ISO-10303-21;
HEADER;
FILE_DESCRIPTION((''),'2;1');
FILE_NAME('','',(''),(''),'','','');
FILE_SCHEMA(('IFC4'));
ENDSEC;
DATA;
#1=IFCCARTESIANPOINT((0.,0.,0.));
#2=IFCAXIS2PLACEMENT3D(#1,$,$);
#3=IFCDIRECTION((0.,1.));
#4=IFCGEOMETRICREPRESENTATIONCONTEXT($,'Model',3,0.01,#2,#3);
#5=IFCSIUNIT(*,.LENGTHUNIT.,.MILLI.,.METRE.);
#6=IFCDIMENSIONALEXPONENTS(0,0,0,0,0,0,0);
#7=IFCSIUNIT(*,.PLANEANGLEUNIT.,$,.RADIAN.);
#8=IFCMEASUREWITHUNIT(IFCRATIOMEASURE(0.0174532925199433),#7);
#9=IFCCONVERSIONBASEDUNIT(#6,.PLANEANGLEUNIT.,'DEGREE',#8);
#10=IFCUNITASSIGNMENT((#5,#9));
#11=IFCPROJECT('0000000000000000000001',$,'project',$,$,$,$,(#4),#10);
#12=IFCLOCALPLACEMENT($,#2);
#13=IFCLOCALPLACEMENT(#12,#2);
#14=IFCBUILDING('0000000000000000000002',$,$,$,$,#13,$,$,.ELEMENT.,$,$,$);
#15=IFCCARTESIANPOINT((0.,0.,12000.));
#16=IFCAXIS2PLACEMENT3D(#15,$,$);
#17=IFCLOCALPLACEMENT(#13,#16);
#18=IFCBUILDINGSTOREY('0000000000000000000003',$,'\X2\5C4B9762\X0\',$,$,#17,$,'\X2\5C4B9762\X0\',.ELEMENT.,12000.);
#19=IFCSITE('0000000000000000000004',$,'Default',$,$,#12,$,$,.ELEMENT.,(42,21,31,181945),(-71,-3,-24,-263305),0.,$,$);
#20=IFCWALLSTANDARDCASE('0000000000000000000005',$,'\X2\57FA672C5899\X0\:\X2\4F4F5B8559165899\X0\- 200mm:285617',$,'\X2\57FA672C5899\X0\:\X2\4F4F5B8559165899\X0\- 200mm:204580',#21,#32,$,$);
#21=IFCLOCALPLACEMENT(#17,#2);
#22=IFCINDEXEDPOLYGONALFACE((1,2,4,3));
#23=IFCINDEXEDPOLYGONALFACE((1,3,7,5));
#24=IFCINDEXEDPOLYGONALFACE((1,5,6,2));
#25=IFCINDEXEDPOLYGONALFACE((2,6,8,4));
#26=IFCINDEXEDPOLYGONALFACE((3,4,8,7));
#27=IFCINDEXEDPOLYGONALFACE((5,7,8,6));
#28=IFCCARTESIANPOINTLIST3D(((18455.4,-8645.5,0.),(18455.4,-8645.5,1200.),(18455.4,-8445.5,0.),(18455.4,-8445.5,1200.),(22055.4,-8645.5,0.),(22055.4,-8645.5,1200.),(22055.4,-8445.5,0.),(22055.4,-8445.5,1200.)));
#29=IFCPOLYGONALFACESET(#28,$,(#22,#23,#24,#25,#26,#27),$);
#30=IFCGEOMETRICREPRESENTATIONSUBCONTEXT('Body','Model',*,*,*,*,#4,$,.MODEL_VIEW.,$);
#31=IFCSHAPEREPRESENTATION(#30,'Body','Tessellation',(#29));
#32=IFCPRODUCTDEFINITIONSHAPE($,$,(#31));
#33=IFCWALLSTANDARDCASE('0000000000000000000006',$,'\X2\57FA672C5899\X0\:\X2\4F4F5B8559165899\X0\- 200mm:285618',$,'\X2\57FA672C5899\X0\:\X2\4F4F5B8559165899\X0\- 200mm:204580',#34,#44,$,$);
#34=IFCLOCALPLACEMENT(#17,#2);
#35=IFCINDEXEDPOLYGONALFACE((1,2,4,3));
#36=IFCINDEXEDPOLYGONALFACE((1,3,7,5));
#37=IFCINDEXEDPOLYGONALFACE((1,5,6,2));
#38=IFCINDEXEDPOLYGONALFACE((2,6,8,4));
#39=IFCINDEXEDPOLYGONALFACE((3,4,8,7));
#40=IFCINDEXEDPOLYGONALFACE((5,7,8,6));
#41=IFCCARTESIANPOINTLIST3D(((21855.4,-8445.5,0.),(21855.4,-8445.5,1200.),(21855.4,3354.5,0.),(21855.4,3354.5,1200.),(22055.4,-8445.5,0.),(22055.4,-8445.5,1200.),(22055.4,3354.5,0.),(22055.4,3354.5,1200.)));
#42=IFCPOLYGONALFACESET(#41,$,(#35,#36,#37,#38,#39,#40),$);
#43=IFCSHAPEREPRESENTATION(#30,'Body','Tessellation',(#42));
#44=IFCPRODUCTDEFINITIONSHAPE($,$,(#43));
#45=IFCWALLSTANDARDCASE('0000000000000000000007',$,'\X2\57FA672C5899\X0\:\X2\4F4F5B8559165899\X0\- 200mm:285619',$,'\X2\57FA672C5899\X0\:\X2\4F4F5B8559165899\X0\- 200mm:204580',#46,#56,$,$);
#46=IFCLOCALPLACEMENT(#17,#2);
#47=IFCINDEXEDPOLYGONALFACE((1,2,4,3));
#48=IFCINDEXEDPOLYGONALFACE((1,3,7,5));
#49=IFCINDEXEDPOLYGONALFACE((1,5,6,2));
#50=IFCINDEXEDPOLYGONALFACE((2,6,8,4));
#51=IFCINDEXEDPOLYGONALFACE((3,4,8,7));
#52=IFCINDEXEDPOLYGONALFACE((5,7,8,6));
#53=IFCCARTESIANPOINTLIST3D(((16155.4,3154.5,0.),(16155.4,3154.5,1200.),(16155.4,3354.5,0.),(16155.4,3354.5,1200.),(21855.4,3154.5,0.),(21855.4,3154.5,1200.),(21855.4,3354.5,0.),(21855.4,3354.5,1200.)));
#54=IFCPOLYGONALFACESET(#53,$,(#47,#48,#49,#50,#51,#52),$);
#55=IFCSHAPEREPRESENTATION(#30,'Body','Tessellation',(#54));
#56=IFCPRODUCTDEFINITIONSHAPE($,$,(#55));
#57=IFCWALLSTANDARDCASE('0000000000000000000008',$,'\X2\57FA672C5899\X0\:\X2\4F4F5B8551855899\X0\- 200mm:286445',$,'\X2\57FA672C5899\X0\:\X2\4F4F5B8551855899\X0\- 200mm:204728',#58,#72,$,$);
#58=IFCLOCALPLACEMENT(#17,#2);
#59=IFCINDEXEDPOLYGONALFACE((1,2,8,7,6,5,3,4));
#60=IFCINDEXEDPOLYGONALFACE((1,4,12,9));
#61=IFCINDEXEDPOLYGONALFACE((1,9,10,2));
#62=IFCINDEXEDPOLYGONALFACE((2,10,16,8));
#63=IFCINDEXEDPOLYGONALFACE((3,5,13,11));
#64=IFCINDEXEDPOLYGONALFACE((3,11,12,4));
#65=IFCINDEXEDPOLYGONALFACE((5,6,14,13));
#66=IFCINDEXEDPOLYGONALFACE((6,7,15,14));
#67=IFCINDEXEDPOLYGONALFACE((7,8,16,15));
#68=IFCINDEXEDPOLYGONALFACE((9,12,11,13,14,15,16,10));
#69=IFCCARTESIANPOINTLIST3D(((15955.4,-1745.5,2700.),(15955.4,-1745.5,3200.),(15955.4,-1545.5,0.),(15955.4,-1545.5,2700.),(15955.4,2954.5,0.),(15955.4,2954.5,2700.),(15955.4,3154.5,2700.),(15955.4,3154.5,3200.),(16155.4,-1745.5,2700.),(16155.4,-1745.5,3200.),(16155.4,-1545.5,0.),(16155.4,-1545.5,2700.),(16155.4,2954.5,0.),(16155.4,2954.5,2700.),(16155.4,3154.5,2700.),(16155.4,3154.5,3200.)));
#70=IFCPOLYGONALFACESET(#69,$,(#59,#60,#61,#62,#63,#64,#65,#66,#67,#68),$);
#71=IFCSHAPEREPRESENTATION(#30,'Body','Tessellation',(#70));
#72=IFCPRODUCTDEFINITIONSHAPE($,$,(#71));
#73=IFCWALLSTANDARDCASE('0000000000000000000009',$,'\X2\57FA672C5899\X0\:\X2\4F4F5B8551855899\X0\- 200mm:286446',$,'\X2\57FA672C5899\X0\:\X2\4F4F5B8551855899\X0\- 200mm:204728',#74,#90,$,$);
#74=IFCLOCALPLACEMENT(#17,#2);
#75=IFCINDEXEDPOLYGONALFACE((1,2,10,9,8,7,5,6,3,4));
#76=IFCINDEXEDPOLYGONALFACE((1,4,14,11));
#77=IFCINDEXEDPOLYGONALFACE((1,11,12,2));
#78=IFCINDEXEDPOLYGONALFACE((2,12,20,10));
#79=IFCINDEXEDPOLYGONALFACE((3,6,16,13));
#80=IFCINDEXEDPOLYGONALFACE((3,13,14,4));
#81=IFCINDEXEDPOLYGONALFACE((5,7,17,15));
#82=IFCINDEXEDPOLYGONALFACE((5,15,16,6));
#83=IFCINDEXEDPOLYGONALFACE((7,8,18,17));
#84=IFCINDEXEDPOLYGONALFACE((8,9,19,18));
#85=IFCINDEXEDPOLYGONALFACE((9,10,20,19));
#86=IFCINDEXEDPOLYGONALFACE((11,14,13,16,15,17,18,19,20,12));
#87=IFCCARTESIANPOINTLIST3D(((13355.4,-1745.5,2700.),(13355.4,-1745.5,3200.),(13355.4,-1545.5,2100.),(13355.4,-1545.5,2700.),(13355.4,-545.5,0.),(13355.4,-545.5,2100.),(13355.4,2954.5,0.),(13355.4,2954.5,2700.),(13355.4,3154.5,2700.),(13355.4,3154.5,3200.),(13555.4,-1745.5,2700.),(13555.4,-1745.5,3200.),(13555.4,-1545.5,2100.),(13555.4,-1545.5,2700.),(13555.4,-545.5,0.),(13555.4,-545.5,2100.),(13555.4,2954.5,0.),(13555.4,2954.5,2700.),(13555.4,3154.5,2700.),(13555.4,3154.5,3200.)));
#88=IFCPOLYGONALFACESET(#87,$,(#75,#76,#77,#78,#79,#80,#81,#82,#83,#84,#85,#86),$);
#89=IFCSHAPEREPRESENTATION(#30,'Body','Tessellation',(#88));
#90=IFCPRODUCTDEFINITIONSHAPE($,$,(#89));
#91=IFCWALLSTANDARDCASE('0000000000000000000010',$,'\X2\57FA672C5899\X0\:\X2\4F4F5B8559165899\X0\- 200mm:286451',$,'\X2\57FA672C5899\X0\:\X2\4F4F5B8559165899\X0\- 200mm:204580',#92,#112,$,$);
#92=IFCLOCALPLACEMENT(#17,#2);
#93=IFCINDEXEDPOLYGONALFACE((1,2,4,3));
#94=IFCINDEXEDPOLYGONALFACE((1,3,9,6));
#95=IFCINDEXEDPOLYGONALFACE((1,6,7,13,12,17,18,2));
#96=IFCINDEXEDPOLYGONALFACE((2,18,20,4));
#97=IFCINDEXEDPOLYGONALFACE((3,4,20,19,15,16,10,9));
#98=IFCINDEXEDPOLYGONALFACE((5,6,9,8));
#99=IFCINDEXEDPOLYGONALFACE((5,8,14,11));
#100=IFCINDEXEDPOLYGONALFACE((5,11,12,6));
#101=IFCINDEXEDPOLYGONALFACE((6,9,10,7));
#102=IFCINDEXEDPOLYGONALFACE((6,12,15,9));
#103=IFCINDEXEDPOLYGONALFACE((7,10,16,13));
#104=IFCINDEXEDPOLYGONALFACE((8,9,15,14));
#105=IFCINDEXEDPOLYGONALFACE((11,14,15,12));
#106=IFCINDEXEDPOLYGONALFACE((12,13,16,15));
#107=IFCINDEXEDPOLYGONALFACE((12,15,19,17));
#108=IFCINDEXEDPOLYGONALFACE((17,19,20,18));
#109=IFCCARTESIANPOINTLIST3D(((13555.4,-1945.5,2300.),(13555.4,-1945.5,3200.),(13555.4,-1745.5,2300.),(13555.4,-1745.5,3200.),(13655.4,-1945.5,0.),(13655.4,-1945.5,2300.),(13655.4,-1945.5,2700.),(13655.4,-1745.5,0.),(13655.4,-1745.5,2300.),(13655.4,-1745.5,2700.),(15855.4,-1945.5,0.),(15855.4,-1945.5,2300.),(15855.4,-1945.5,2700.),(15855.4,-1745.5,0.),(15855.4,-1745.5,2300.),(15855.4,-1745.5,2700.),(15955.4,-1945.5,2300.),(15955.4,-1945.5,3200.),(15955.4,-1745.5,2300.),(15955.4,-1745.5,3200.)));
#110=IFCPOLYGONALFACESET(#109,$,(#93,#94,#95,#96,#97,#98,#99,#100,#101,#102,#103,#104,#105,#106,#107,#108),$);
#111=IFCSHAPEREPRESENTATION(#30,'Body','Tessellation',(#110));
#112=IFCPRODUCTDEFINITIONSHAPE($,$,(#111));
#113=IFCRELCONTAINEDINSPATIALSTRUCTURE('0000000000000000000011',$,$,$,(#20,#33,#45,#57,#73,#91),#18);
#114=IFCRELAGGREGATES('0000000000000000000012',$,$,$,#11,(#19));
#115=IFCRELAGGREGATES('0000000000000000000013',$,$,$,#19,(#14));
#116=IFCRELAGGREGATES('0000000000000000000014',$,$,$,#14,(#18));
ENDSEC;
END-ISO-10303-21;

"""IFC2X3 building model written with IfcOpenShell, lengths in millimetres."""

from ifc_helpers import new_model, entity, si_unit, converted_unit, direction, frame, frame_2d, origin, place, context, subcontext, project, spatial, polyline, rectangle, extrude, clip, bounded_halfspace, element, save


model = new_model("IFC2X3")

# Units and contexts
model_context = context("Model", 3, precision=0.01, world=origin(), true_north=direction((0.0, 1.0)))
body_context = subcontext(model_context, "Body", "Model", "MODEL_VIEW")
ifc_project = project(units=[si_unit("LENGTHUNIT", "METRE", prefix="MILLI"), converted_unit("PLANEANGLEUNIT", "DEGREE", entity("IfcRatioMeasure", 0.0174532925199433), si_unit("PLANEANGLEUNIT", "RADIAN"), dimensions=[0, 0, 0, 0, 0, 0, 0])], contexts=[model_context])

# Site, building, storey
site_placement = place(None, origin())
site = spatial("IfcSite", under=ifc_project, at=site_placement, Name="Default", CompositionType="ELEMENT", RefLatitude=(42, 21, 31, 181945), RefLongitude=(-71, -3, -24, -263305), RefElevation=0.0)
building_placement = place(site_placement, origin())
building = spatial("IfcBuilding", under=site, at=building_placement, CompositionType="ELEMENT")
storey_placement = place(building_placement, frame((0.0, 0.0, 12000.0)))
storey = spatial("IfcBuildingStorey", under=building, at=storey_placement, Name="屋面", LongName="屋面", CompositionType="ELEMENT", Elevation=12000.0)

# Walls
wall_1_placement = place(storey_placement, frame((18455.4, -8545.5, 0.0)))
element("IfcWallStandardCase", 1, at=wall_1_placement, inside=storey, Name="基本墙:住宅外墙- 200mm:285617", ObjectType="基本墙:住宅外墙- 200mm:204580", context=body_context, shape_type="SweptSolid", body=[
    extrude(rectangle(XDim=3600.0, YDim=200.0, at=frame_2d((1800.0, 0.0), x_axis=(-1.0, 0.0))), origin(), (0.0, 0.0, 1.0), 1200.0),
])
wall_2_placement = place(storey_placement, frame((21955.4, -8445.5, 0.0), z_axis=(0.0, 0.0, 1.0), x_axis=(0.0, 1.0, 0.0)))
element("IfcWallStandardCase", 2, at=wall_2_placement, inside=storey, Name="基本墙:住宅外墙- 200mm:285618", ObjectType="基本墙:住宅外墙- 200mm:204580", context=body_context, shape_type="SweptSolid", body=[
    extrude(rectangle(XDim=11800.0, YDim=200.0, at=frame_2d((5900.0, 0.0), x_axis=(-1.0, 0.0))), origin(), (0.0, 0.0, 1.0), 1200.0),
])
wall_3_placement = place(storey_placement, frame((21855.4, 3254.5, 0.0), z_axis=(0.0, 0.0, 1.0), x_axis=(-1.0, 0.0, 0.0)))
element("IfcWallStandardCase", 3, at=wall_3_placement, inside=storey, Name="基本墙:住宅外墙- 200mm:285619", ObjectType="基本墙:住宅外墙- 200mm:204580", context=body_context, shape_type="SweptSolid", body=[
    extrude(rectangle(XDim=5700.0, YDim=200.0, at=frame_2d((2850.0, 0.0), x_axis=(-1.0, 0.0))), origin(), (0.0, 0.0, 1.0), 1200.0),
])
wall_4_placement = place(storey_placement, frame((16055.4, 3154.5, 0.0), z_axis=(0.0, 0.0, 1.0), x_axis=(0.0, -1.0, 0.0)))
element("IfcWallStandardCase", 4, at=wall_4_placement, inside=storey, Name="基本墙:住宅内墙- 200mm:286445", ObjectType="基本墙:住宅内墙- 200mm:204728", context=body_context, shape_type="Clipping", body=[
    clip(clip(clip(clip(extrude(rectangle(XDim=4900.0, YDim=200.0, at=frame_2d((2450.0, 0.0), x_axis=(-1.0, 0.0))), origin(), (0.0, 0.0, 1.0), 3200.0), bounded_halfspace(frame((200.0, -100.0, 2700.0), z_axis=(-1.0, 0.0, 0.0), x_axis=(0.0, 0.0, -1.0)), False, frame((200.0, -100.0, 2700.0), z_axis=(-1.0, 0.0, 0.0), x_axis=(0.0, 0.0, -1.0)), polyline([(0.0, 0.0), (0.0, -200.0), (2700.0, -200.0), (2700.0, 0.0), (0.0, 0.0)]))), bounded_halfspace(frame((200.0, 100.0, 2700.0), z_axis=(0.0, 0.0, -1.0), x_axis=(0.0, 1.0, 0.0)), False, frame((200.0, 100.0, 2700.0), z_axis=(0.0, 0.0, -1.0), x_axis=(0.0, 1.0, 0.0)), polyline([(0.0, 0.0), (-200.0, 0.0), (-200.0, -200.0), (0.0, -200.0), (0.0, 0.0)]))), bounded_halfspace(frame((4700.0, 100.0, 2700.0), z_axis=(-1.0, 0.0, 0.0), x_axis=(0.0, 0.0, -1.0)), True, frame((4700.0, 100.0, 2700.0), z_axis=(-1.0, 0.0, 0.0), x_axis=(0.0, 0.0, -1.0)), polyline([(0.0, 0.0), (2700.0, 0.0), (2700.0, 200.0), (0.0, 200.0), (0.0, 0.0)]))), bounded_halfspace(frame((4700.0, -100.0, 2700.0), z_axis=(0.0, 0.0, 1.0), x_axis=(0.0, -1.0, 0.0)), True, frame((4700.0, -100.0, 2700.0), z_axis=(0.0, 0.0, 1.0), x_axis=(0.0, -1.0, 0.0)), polyline([(0.0, 0.0), (0.0, 200.0), (-200.0, 200.0), (-200.0, 0.0), (0.0, 0.0)]))),
])

# Walls, openings
wall_5_placement = place(storey_placement, frame((13455.4, -1745.5, 0.0), z_axis=(0.0, 0.0, 1.0), x_axis=(0.0, 1.0, 0.0)))
wall_5 = element("IfcWallStandardCase", 5, at=wall_5_placement, inside=storey, Name="基本墙:住宅内墙- 200mm:286446", ObjectType="基本墙:住宅内墙- 200mm:204728", context=body_context, shape_type="Clipping", body=[
    clip(clip(clip(clip(extrude(rectangle(XDim=4900.0, YDim=200.0, at=frame_2d((2450.0, 0.0), x_axis=(-1.0, 0.0))), origin(), (0.0, 0.0, 1.0), 3200.0), bounded_halfspace(frame((200.0, -100.0, 2700.0), z_axis=(1.0, 0.0, 0.0), x_axis=(0.0, 0.0, -1.0)), True, frame((200.0, -100.0, 2700.0), z_axis=(1.0, 0.0, 0.0), x_axis=(0.0, 0.0, -1.0)), polyline([(0.0, 0.0), (600.0, 0.0), (600.0, 200.0), (0.0, 200.0), (0.0, 0.0)]))), bounded_halfspace(frame((200.0, 100.0, 2700.0), z_axis=(0.0, 0.0, 1.0), x_axis=(0.0, 1.0, 0.0)), True, frame((200.0, 100.0, 2700.0), z_axis=(0.0, 0.0, 1.0), x_axis=(0.0, 1.0, 0.0)), polyline([(0.0, 0.0), (0.0, 200.0), (-200.0, 200.0), (-200.0, 0.0), (0.0, 0.0)]))), bounded_halfspace(frame((4700.0, 100.0, 2700.0), z_axis=(-1.0, 0.0, 0.0), x_axis=(0.0, 0.0, -1.0)), True, frame((4700.0, 100.0, 2700.0), z_axis=(-1.0, 0.0, 0.0), x_axis=(0.0, 0.0, -1.0)), polyline([(0.0, 0.0), (2700.0, 0.0), (2700.0, 200.0), (0.0, 200.0), (0.0, 0.0)]))), bounded_halfspace(frame((4700.0, -100.0, 2700.0), z_axis=(0.0, 0.0, 1.0), x_axis=(0.0, 1.0, 0.0)), True, frame((4700.0, -100.0, 2700.0), z_axis=(0.0, 0.0, 1.0), x_axis=(0.0, 1.0, 0.0)), polyline([(0.0, 0.0), (0.0, -200.0), (200.0, -200.0), (200.0, 0.0), (0.0, 0.0)]))),
])
opening_1_placement = place(wall_5_placement, frame((1200.0, 100.0, 0.0)))
element("IfcOpeningElement", 6, at=opening_1_placement, cuts=wall_5, ObjectType="Opening", context=body_context, shape_type="SweptSolid", body=[
    extrude(rectangle(XDim=2100.0, YDim=1000.0, at=frame_2d((1050.0, 500.0), x_axis=(1.0, 0.0))), frame((0.0, 0.0, 0.0), z_axis=(0.0, -1.0, 0.0), x_axis=(0.0, 0.0, 1.0)), (0.0, 0.0, 1.0), 200.0),
])
wall_6_placement = place(storey_placement, frame((15955.4, -1845.5, 0.0), z_axis=(0.0, 0.0, 1.0), x_axis=(-1.0, 0.0, 0.0)))
wall_6 = element("IfcWallStandardCase", 7, at=wall_6_placement, inside=storey, Name="基本墙:住宅外墙- 200mm:286451", ObjectType="基本墙:住宅外墙- 200mm:204580", context=body_context, shape_type="Clipping", body=[
    clip(clip(extrude(rectangle(XDim=2400.0, YDim=200.0, at=frame_2d((1200.0, 0.0), x_axis=(-1.0, 0.0))), origin(), (0.0, 0.0, 1.0), 3200.0), bounded_halfspace(frame((2300.0, -100.0, 2300.0), z_axis=(-1.0, 0.0, 0.0), x_axis=(0.0, 0.0, -1.0)), True, frame((2300.0, -100.0, 2300.0), z_axis=(-1.0, 0.0, 0.0), x_axis=(0.0, 0.0, -1.0)), polyline([(0.0, 0.0), (0.0, -200.0), (2300.0, -200.0), (2300.0, 0.0), (0.0, 0.0)]))), bounded_halfspace(frame((100.0, -100.0, 0.0), z_axis=(1.0, 0.0, 0.0), x_axis=(0.0, 0.0, -1.0)), True, frame((100.0, -100.0, 0.0), z_axis=(1.0, 0.0, 0.0), x_axis=(0.0, 0.0, -1.0)), polyline([(0.0, 0.0), (0.0, 200.0), (-2300.0, 200.0), (-2300.0, 0.0), (0.0, 0.0)]))),
])
opening_2_placement = place(storey_placement, frame((15955.4, -1845.5, 0.0), z_axis=(0.0, 0.0, 1.0), x_axis=(-1.0, 0.0, 0.0)))
element("IfcOpeningElement", 8, at=opening_2_placement, cuts=wall_6, ObjectType="Opening", context=body_context, shape_type="SweptSolid", body=[
    extrude(rectangle(XDim=200.0, YDim=2200.0, at=frame_2d((0.0, 0.0), x_axis=(1.0, 0.0))), frame((1200.0, 0.0, 2300.0), z_axis=(0.0, 0.0, 1.0), x_axis=(0.0, 1.0, 0.0)), (0.0, 0.0, 1.0), 400.0),
])

save(model, "model.ifc")
